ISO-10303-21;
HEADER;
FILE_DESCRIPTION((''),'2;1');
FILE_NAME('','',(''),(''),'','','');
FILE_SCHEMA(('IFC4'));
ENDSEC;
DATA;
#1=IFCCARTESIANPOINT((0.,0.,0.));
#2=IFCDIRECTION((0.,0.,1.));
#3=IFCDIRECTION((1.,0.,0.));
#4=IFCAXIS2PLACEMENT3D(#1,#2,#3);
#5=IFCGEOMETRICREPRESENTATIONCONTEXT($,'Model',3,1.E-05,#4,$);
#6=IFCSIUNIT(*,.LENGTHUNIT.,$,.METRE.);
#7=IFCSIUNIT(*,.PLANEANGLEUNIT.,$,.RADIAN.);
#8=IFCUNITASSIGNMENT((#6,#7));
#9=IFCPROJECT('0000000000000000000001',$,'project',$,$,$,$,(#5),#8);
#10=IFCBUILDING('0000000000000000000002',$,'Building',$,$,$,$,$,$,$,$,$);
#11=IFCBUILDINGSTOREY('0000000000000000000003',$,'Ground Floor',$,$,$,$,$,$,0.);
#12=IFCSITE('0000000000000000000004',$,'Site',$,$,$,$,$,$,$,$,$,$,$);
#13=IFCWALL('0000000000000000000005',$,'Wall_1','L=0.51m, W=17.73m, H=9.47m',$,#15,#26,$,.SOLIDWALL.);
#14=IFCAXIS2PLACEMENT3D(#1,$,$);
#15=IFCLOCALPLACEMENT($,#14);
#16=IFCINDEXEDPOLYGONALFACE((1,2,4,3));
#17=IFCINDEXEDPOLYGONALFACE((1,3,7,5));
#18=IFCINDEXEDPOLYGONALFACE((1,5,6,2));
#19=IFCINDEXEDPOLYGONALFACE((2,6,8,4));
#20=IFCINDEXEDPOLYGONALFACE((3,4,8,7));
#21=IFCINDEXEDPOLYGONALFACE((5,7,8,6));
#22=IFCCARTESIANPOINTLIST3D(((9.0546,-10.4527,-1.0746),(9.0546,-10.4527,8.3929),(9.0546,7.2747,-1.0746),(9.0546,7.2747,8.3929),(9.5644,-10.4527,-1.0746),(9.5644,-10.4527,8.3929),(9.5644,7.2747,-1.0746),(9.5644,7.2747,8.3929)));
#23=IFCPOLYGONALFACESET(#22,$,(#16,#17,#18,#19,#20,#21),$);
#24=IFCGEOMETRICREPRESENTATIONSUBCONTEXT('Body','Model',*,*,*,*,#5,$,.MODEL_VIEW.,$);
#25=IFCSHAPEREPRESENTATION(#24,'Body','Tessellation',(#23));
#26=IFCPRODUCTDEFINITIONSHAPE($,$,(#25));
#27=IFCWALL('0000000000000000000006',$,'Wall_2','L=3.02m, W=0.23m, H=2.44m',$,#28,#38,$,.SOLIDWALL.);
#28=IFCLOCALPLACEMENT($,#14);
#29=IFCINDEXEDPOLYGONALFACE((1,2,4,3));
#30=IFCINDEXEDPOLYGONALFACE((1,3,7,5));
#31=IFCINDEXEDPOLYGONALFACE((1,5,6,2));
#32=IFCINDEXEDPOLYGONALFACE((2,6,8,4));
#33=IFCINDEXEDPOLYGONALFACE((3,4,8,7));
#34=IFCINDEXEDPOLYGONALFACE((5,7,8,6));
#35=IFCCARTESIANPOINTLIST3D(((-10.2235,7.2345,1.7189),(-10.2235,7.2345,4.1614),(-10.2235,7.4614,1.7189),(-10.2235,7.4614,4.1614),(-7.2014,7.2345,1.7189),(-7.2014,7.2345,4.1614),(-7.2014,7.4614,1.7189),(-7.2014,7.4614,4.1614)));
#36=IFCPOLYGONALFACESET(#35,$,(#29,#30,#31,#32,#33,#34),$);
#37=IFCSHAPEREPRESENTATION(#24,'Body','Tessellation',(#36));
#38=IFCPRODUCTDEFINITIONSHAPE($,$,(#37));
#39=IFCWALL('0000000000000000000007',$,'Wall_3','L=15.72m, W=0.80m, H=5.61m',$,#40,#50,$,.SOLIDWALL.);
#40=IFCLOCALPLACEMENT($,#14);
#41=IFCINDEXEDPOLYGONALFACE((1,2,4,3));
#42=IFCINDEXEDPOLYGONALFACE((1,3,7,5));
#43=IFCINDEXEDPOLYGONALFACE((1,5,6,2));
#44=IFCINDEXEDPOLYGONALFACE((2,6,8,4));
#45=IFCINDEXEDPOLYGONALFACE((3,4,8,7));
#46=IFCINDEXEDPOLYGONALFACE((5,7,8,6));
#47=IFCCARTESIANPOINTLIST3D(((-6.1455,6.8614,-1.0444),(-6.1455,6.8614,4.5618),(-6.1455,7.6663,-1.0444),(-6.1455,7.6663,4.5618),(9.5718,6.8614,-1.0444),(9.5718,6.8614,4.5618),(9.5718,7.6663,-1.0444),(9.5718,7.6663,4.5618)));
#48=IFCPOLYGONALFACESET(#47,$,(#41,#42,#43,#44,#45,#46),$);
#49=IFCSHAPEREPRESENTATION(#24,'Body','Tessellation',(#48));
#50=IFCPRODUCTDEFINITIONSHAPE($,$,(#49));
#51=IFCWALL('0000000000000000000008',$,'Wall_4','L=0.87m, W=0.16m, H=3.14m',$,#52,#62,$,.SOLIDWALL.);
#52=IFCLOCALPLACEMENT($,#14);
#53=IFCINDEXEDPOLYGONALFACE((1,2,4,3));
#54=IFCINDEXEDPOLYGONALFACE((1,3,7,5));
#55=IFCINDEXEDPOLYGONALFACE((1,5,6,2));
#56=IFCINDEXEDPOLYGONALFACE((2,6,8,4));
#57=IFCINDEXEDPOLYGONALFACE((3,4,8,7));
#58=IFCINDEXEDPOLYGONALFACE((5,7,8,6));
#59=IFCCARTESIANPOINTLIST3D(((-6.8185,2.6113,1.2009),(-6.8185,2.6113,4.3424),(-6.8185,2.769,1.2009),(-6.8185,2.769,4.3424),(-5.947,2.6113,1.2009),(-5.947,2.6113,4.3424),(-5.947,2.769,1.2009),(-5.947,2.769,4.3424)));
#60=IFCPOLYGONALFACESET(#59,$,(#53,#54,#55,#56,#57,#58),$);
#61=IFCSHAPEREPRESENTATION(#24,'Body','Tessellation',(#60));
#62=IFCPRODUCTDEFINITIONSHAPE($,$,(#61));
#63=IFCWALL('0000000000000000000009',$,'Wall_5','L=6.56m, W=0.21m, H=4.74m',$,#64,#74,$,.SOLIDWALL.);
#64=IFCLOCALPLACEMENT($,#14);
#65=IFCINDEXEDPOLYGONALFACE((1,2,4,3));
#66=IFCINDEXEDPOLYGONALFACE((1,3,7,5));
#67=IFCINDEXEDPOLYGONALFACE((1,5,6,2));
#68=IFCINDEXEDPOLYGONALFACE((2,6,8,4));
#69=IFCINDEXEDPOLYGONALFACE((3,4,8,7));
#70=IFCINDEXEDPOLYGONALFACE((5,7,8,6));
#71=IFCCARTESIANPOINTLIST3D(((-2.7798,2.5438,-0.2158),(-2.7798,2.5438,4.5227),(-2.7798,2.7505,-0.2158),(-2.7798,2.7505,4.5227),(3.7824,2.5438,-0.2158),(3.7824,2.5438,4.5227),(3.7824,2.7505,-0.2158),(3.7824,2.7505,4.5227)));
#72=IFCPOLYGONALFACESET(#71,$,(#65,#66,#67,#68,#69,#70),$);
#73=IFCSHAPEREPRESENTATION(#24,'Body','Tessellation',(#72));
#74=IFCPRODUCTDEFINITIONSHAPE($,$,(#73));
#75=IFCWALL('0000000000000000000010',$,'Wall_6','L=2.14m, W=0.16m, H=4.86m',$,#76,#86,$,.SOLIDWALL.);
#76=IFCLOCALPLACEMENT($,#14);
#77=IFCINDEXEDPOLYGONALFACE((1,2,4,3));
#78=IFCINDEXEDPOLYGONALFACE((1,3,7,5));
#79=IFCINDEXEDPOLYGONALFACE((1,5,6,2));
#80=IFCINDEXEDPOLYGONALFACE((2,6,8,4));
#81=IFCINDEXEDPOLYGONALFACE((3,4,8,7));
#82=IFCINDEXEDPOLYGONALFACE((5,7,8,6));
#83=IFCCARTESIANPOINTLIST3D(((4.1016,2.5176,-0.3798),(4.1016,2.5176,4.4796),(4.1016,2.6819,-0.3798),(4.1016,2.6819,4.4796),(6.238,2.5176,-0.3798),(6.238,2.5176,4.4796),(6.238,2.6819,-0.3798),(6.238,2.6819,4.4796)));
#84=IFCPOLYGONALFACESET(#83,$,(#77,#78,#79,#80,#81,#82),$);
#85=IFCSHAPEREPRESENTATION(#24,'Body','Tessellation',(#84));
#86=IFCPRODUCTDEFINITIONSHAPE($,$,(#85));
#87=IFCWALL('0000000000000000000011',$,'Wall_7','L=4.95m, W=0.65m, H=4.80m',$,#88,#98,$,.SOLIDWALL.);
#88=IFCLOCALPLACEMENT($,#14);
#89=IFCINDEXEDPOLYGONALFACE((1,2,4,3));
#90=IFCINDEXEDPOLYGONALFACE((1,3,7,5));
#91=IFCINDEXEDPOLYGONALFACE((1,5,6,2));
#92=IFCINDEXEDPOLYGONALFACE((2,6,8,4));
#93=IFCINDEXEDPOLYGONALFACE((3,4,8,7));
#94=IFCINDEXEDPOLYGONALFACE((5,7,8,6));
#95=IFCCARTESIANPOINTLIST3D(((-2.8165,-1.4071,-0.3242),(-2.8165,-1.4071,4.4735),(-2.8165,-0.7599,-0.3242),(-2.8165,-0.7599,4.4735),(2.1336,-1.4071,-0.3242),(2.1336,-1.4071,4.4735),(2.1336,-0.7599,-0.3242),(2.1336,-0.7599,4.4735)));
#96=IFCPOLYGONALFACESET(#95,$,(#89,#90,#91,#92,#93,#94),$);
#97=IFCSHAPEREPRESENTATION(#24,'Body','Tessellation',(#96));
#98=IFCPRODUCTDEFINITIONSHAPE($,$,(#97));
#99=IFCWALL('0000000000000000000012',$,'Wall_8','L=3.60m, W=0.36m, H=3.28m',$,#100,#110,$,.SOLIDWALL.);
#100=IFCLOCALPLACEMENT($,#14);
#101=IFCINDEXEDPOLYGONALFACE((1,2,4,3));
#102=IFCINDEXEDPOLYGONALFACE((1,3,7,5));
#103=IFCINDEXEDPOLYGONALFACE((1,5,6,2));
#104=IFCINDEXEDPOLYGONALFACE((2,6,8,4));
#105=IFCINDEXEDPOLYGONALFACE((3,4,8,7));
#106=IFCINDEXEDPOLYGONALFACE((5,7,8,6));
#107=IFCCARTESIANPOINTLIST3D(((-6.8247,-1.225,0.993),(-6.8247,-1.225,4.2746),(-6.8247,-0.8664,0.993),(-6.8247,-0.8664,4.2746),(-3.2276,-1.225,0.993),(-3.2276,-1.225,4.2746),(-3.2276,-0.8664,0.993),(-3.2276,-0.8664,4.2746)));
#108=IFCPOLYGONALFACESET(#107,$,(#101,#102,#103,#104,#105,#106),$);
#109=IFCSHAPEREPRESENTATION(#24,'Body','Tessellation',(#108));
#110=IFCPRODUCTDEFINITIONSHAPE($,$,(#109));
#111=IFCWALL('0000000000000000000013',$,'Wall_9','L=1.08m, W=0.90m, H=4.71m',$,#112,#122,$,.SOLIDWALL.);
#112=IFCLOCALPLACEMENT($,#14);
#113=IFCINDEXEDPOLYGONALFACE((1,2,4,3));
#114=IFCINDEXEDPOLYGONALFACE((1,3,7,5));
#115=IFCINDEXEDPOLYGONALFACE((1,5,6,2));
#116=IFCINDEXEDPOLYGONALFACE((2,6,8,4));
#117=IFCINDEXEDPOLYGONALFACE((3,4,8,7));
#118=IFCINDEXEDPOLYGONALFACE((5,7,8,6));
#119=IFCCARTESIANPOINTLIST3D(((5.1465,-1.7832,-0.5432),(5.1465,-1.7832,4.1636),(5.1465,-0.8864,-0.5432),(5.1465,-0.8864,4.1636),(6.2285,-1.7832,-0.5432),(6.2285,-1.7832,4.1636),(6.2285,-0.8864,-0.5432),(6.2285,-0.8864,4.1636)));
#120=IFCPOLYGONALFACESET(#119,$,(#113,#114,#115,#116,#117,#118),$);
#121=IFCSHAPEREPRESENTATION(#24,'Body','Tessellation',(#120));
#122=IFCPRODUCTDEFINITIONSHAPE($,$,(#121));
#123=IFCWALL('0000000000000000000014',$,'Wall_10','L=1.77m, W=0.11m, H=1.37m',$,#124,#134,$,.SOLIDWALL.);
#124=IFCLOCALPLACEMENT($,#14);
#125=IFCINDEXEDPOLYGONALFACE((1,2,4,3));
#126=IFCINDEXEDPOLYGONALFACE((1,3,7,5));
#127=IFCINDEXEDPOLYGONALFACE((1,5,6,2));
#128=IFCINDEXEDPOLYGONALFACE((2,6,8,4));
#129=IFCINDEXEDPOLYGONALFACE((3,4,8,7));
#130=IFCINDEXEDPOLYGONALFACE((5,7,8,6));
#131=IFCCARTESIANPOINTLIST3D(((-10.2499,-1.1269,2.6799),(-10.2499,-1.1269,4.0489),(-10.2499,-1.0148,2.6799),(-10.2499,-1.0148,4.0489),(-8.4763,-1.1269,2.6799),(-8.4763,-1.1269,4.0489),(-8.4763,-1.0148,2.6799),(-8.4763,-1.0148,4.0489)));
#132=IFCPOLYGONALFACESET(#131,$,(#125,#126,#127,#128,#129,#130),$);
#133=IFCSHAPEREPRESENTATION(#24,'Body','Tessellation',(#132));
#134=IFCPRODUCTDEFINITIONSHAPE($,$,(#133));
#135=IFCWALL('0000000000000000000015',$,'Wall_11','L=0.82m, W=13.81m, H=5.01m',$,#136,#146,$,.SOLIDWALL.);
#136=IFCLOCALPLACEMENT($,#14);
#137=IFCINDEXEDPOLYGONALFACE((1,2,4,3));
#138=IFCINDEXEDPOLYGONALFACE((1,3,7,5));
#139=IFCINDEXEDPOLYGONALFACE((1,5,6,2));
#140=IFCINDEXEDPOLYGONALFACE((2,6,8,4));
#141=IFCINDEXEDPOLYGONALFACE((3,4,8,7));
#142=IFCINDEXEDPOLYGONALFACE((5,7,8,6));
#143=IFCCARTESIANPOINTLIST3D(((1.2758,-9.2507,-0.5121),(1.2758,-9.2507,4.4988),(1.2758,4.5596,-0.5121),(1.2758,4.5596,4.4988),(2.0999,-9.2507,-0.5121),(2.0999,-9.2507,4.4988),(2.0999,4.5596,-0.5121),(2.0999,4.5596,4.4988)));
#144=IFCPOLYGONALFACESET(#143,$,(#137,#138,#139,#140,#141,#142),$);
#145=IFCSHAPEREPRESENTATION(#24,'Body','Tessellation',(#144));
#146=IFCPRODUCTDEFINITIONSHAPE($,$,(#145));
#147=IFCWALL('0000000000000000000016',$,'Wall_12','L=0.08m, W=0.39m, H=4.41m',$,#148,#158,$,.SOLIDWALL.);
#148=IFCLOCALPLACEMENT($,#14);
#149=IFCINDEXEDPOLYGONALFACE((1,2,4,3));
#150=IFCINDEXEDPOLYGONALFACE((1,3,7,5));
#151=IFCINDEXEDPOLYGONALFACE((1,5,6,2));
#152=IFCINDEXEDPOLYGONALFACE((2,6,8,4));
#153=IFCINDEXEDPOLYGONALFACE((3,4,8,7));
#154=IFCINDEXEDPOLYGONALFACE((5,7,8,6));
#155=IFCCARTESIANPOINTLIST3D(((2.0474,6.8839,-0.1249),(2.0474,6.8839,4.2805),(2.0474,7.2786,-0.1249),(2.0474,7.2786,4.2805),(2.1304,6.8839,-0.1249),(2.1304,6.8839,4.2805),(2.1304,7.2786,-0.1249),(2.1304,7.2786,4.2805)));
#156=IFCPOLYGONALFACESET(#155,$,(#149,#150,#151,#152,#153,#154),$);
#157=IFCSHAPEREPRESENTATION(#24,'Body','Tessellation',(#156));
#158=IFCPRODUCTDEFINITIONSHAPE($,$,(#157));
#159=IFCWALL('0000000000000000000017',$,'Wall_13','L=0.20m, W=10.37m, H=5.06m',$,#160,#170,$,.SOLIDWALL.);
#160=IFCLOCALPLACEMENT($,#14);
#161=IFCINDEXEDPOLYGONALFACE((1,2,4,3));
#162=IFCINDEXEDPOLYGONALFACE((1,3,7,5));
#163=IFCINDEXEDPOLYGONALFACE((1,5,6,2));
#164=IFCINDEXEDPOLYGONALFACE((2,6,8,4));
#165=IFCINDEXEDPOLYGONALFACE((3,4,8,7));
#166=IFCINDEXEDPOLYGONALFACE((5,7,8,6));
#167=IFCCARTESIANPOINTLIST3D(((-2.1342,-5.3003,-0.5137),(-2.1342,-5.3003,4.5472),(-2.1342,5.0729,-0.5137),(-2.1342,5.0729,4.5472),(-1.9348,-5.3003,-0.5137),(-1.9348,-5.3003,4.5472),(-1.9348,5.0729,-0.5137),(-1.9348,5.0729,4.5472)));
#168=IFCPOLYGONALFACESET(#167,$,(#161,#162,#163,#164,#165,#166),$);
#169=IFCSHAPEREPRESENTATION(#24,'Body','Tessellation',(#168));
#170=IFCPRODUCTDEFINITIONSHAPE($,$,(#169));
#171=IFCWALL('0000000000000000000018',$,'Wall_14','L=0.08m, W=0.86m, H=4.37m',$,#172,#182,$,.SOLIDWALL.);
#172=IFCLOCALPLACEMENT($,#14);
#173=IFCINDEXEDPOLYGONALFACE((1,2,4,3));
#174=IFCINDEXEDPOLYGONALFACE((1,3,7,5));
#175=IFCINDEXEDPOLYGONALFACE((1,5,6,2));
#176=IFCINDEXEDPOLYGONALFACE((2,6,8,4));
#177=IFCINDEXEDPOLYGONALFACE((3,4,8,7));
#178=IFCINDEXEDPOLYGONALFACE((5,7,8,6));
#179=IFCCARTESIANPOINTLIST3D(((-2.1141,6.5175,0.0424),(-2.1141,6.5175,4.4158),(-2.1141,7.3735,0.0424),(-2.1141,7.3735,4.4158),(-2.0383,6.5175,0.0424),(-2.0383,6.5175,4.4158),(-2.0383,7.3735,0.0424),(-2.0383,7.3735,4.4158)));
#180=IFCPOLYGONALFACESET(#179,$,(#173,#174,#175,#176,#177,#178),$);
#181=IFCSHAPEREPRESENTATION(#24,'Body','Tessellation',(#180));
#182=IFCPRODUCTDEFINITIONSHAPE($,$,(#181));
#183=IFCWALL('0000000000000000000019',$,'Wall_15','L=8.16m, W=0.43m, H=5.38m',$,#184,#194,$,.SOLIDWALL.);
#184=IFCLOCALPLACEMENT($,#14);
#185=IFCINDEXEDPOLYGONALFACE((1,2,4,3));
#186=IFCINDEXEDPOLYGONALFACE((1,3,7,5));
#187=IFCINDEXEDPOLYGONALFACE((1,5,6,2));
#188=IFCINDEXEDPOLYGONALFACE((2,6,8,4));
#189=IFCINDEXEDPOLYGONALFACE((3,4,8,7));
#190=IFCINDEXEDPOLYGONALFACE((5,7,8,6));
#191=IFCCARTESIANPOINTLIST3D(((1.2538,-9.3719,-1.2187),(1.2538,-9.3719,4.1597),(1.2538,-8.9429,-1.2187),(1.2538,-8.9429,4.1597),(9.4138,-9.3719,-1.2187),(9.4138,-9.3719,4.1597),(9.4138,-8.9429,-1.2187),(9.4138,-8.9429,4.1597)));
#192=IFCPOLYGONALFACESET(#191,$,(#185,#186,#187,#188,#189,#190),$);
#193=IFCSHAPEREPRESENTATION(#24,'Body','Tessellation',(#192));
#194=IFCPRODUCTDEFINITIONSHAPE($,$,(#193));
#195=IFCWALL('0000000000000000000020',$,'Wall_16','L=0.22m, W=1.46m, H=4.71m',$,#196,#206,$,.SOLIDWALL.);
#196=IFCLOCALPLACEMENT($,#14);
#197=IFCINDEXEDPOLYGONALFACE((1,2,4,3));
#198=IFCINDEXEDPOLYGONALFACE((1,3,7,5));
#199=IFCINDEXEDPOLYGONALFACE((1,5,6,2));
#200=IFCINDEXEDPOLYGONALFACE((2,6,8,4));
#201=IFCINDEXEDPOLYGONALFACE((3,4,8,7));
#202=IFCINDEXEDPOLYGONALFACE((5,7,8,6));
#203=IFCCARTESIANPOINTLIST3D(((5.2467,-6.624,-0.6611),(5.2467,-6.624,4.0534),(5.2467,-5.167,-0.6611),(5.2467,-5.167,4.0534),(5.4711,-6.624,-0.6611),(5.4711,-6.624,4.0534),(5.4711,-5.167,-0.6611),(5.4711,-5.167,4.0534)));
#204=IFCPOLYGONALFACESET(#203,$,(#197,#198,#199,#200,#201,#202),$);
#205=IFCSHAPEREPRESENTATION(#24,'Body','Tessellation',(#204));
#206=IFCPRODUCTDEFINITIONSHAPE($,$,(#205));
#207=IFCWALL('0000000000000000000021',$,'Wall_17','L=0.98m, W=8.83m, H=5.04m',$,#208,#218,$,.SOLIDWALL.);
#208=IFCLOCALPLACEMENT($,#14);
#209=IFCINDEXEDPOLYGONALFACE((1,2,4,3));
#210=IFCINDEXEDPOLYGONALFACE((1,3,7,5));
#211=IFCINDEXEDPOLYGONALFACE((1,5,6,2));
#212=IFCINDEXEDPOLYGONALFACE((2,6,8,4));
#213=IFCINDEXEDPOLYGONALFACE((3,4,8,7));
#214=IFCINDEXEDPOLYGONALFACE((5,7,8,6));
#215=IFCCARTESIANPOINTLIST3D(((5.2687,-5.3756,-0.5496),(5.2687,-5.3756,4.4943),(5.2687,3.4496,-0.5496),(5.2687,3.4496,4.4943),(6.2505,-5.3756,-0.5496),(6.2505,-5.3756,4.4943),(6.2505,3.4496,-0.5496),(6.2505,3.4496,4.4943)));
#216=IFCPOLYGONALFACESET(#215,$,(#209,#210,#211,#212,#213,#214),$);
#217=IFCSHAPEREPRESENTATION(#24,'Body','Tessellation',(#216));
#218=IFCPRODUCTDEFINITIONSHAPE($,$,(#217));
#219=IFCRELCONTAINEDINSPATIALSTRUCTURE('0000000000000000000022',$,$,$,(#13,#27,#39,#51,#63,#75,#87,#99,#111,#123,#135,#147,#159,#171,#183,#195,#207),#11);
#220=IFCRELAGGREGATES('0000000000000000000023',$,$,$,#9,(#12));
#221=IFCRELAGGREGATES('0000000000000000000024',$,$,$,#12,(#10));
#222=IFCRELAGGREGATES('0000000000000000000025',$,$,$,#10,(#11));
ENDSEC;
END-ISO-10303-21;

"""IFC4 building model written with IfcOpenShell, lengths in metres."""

from ifc_helpers import new_model, si_unit, frame, origin_with_axes, origin_2d, context, subcontext, project, spatial, rectangle, extrude, element, save


model = new_model("IFC4")

# Units and contexts
model_context = context("Model", 3, precision=1e-05, world=origin_with_axes())
body_context = subcontext(model_context, "Body", "Model", "MODEL_VIEW")
ifc_project = project(units=[si_unit("LENGTHUNIT", "METRE"), si_unit("PLANEANGLEUNIT", "RADIAN")], contexts=[model_context])

# Site, building, storey
site = spatial("IfcSite", under=ifc_project, Name="Site")
building = spatial("IfcBuilding", under=site, Name="Building")
storey = spatial("IfcBuildingStorey", under=building, Name="Ground Floor", Elevation=0.0)

# Walls
element("IfcWall", 1, inside=storey, Name="Wall_1", Description="L=0.51m, W=17.73m, H=9.47m", PredefinedType="SOLIDWALL", context=body_context, shape_type="SweptSolid", body=[
    extrude(rectangle(XDim=0.5098, YDim=17.7274, at=origin_2d()), frame((9.3095, -1.589, -1.0746), z_axis=(0.0, 0.0, 1.0), x_axis=(1.0, 0.0, 0.0)), (0.0, 0.0, 1.0), 9.4676),
])
element("IfcWall", 2, inside=storey, Name="Wall_2", Description="L=3.02m, W=0.23m, H=2.44m", PredefinedType="SOLIDWALL", context=body_context, shape_type="SweptSolid", body=[
    extrude(rectangle(XDim=3.0221, YDim=0.2269, at=origin_2d()), frame((-8.7125, 7.3479, 1.7189), z_axis=(0.0, 0.0, 1.0), x_axis=(1.0, 0.0, 0.0)), (0.0, 0.0, 1.0), 2.4425),
])
element("IfcWall", 3, inside=storey, Name="Wall_3", Description="L=15.72m, W=0.80m, H=5.61m", PredefinedType="SOLIDWALL", context=body_context, shape_type="SweptSolid", body=[
    extrude(rectangle(XDim=15.7173, YDim=0.8049, at=origin_2d()), frame((1.7131, 7.2639, -1.0444), z_axis=(0.0, 0.0, 1.0), x_axis=(1.0, 0.0, 0.0)), (0.0, 0.0, 1.0), 5.6062),
])
element("IfcWall", 4, inside=storey, Name="Wall_4", Description="L=0.87m, W=0.16m, H=3.14m", PredefinedType="SOLIDWALL", context=body_context, shape_type="SweptSolid", body=[
    extrude(rectangle(XDim=0.8715, YDim=0.1577, at=origin_2d()), frame((-6.3827, 2.6902, 1.2009), z_axis=(0.0, 0.0, 1.0), x_axis=(1.0, 0.0, 0.0)), (0.0, 0.0, 1.0), 3.1415),
])
element("IfcWall", 5, inside=storey, Name="Wall_5", Description="L=6.56m, W=0.21m, H=4.74m", PredefinedType="SOLIDWALL", context=body_context, shape_type="SweptSolid", body=[
    extrude(rectangle(XDim=6.5622, YDim=0.2067, at=origin_2d()), frame((0.5013, 2.6471, -0.2158), z_axis=(0.0, 0.0, 1.0), x_axis=(1.0, 0.0, 0.0)), (0.0, 0.0, 1.0), 4.7384),
])
element("IfcWall", 6, inside=storey, Name="Wall_6", Description="L=2.14m, W=0.16m, H=4.86m", PredefinedType="SOLIDWALL", context=body_context, shape_type="SweptSolid", body=[
    extrude(rectangle(XDim=2.1364, YDim=0.1644, at=origin_2d()), frame((5.1698, 2.5997, -0.3798), z_axis=(0.0, 0.0, 1.0), x_axis=(1.0, 0.0, 0.0)), (0.0, 0.0, 1.0), 4.8594),
])
element("IfcWall", 7, inside=storey, Name="Wall_7", Description="L=4.95m, W=0.65m, H=4.80m", PredefinedType="SOLIDWALL", context=body_context, shape_type="SweptSolid", body=[
    extrude(rectangle(XDim=4.9501, YDim=0.6473, at=origin_2d()), frame((-0.3415, -1.0835, -0.3242), z_axis=(0.0, 0.0, 1.0), x_axis=(1.0, 0.0, 0.0)), (0.0, 0.0, 1.0), 4.7978),
])
element("IfcWall", 8, inside=storey, Name="Wall_8", Description="L=3.60m, W=0.36m, H=3.28m", PredefinedType="SOLIDWALL", context=body_context, shape_type="SweptSolid", body=[
    extrude(rectangle(XDim=3.5971, YDim=0.3586, at=origin_2d()), frame((-5.0262, -1.0457, 0.993), z_axis=(0.0, 0.0, 1.0), x_axis=(1.0, 0.0, 0.0)), (0.0, 0.0, 1.0), 3.2816),
])
element("IfcWall", 9, inside=storey, Name="Wall_9", Description="L=1.08m, W=0.90m, H=4.71m", PredefinedType="SOLIDWALL", context=body_context, shape_type="SweptSolid", body=[
    extrude(rectangle(XDim=1.082, YDim=0.8968, at=origin_2d()), frame((5.6875, -1.3348, -0.5432), z_axis=(0.0, 0.0, 1.0), x_axis=(1.0, 0.0, 0.0)), (0.0, 0.0, 1.0), 4.7068),
])
element("IfcWall", 10, inside=storey, Name="Wall_10", Description="L=1.77m, W=0.11m, H=1.37m", PredefinedType="SOLIDWALL", context=body_context, shape_type="SweptSolid", body=[
    extrude(rectangle(XDim=1.7736, YDim=0.112, at=origin_2d()), frame((-9.3631, -1.0709, 2.6799), z_axis=(0.0, 0.0, 1.0), x_axis=(1.0, 0.0, 0.0)), (0.0, 0.0, 1.0), 1.3689),
])
element("IfcWall", 11, inside=storey, Name="Wall_11", Description="L=0.82m, W=13.81m, H=5.01m", PredefinedType="SOLIDWALL", context=body_context, shape_type="SweptSolid", body=[
    extrude(rectangle(XDim=0.8241, YDim=13.8103, at=origin_2d()), frame((1.6878, -2.3456, -0.5121), z_axis=(0.0, 0.0, 1.0), x_axis=(1.0, 0.0, 0.0)), (0.0, 0.0, 1.0), 5.011),
])
element("IfcWall", 12, inside=storey, Name="Wall_12", Description="L=0.08m, W=0.39m, H=4.41m", PredefinedType="SOLIDWALL", context=body_context, shape_type="SweptSolid", body=[
    extrude(rectangle(XDim=0.083, YDim=0.3947, at=origin_2d()), frame((2.0889, 7.0812, -0.1249), z_axis=(0.0, 0.0, 1.0), x_axis=(1.0, 0.0, 0.0)), (0.0, 0.0, 1.0), 4.4055),
])
element("IfcWall", 13, inside=storey, Name="Wall_13", Description="L=0.20m, W=10.37m, H=5.06m", PredefinedType="SOLIDWALL", context=body_context, shape_type="SweptSolid", body=[
    extrude(rectangle(XDim=0.1994, YDim=10.3731, at=origin_2d()), frame((-2.0345, -0.1137, -0.5137), z_axis=(0.0, 0.0, 1.0), x_axis=(1.0, 0.0, 0.0)), (0.0, 0.0, 1.0), 5.0609),
])
element("IfcWall", 14, inside=storey, Name="Wall_14", Description="L=0.08m, W=0.86m, H=4.37m", PredefinedType="SOLIDWALL", context=body_context, shape_type="SweptSolid", body=[
    extrude(rectangle(XDim=0.0758, YDim=0.856, at=origin_2d()), frame((-2.0762, 6.9455, 0.0424), z_axis=(0.0, 0.0, 1.0), x_axis=(1.0, 0.0, 0.0)), (0.0, 0.0, 1.0), 4.3734),
])
element("IfcWall", 15, inside=storey, Name="Wall_15", Description="L=8.16m, W=0.43m, H=5.38m", PredefinedType="SOLIDWALL", context=body_context, shape_type="SweptSolid", body=[
    extrude(rectangle(XDim=8.16, YDim=0.429, at=origin_2d()), frame((5.3338, -9.1574, -1.2187), z_axis=(0.0, 0.0, 1.0), x_axis=(1.0, 0.0, 0.0)), (0.0, 0.0, 1.0), 5.3784),
])
element("IfcWall", 16, inside=storey, Name="Wall_16", Description="L=0.22m, W=1.46m, H=4.71m", PredefinedType="SOLIDWALL", context=body_context, shape_type="SweptSolid", body=[
    extrude(rectangle(XDim=0.2244, YDim=1.4569, at=origin_2d()), frame((5.3589, -5.8955, -0.6611), z_axis=(0.0, 0.0, 1.0), x_axis=(1.0, 0.0, 0.0)), (0.0, 0.0, 1.0), 4.7145),
])
element("IfcWall", 17, inside=storey, Name="Wall_17", Description="L=0.98m, W=8.83m, H=5.04m", PredefinedType="SOLIDWALL", context=body_context, shape_type="SweptSolid", body=[
    extrude(rectangle(XDim=0.9818, YDim=8.8252, at=origin_2d()), frame((5.7596, -0.963, -0.5496), z_axis=(0.0, 0.0, 1.0), x_axis=(1.0, 0.0, 0.0)), (0.0, 0.0, 1.0), 5.0439),
])

save(model, "model.ifc")
